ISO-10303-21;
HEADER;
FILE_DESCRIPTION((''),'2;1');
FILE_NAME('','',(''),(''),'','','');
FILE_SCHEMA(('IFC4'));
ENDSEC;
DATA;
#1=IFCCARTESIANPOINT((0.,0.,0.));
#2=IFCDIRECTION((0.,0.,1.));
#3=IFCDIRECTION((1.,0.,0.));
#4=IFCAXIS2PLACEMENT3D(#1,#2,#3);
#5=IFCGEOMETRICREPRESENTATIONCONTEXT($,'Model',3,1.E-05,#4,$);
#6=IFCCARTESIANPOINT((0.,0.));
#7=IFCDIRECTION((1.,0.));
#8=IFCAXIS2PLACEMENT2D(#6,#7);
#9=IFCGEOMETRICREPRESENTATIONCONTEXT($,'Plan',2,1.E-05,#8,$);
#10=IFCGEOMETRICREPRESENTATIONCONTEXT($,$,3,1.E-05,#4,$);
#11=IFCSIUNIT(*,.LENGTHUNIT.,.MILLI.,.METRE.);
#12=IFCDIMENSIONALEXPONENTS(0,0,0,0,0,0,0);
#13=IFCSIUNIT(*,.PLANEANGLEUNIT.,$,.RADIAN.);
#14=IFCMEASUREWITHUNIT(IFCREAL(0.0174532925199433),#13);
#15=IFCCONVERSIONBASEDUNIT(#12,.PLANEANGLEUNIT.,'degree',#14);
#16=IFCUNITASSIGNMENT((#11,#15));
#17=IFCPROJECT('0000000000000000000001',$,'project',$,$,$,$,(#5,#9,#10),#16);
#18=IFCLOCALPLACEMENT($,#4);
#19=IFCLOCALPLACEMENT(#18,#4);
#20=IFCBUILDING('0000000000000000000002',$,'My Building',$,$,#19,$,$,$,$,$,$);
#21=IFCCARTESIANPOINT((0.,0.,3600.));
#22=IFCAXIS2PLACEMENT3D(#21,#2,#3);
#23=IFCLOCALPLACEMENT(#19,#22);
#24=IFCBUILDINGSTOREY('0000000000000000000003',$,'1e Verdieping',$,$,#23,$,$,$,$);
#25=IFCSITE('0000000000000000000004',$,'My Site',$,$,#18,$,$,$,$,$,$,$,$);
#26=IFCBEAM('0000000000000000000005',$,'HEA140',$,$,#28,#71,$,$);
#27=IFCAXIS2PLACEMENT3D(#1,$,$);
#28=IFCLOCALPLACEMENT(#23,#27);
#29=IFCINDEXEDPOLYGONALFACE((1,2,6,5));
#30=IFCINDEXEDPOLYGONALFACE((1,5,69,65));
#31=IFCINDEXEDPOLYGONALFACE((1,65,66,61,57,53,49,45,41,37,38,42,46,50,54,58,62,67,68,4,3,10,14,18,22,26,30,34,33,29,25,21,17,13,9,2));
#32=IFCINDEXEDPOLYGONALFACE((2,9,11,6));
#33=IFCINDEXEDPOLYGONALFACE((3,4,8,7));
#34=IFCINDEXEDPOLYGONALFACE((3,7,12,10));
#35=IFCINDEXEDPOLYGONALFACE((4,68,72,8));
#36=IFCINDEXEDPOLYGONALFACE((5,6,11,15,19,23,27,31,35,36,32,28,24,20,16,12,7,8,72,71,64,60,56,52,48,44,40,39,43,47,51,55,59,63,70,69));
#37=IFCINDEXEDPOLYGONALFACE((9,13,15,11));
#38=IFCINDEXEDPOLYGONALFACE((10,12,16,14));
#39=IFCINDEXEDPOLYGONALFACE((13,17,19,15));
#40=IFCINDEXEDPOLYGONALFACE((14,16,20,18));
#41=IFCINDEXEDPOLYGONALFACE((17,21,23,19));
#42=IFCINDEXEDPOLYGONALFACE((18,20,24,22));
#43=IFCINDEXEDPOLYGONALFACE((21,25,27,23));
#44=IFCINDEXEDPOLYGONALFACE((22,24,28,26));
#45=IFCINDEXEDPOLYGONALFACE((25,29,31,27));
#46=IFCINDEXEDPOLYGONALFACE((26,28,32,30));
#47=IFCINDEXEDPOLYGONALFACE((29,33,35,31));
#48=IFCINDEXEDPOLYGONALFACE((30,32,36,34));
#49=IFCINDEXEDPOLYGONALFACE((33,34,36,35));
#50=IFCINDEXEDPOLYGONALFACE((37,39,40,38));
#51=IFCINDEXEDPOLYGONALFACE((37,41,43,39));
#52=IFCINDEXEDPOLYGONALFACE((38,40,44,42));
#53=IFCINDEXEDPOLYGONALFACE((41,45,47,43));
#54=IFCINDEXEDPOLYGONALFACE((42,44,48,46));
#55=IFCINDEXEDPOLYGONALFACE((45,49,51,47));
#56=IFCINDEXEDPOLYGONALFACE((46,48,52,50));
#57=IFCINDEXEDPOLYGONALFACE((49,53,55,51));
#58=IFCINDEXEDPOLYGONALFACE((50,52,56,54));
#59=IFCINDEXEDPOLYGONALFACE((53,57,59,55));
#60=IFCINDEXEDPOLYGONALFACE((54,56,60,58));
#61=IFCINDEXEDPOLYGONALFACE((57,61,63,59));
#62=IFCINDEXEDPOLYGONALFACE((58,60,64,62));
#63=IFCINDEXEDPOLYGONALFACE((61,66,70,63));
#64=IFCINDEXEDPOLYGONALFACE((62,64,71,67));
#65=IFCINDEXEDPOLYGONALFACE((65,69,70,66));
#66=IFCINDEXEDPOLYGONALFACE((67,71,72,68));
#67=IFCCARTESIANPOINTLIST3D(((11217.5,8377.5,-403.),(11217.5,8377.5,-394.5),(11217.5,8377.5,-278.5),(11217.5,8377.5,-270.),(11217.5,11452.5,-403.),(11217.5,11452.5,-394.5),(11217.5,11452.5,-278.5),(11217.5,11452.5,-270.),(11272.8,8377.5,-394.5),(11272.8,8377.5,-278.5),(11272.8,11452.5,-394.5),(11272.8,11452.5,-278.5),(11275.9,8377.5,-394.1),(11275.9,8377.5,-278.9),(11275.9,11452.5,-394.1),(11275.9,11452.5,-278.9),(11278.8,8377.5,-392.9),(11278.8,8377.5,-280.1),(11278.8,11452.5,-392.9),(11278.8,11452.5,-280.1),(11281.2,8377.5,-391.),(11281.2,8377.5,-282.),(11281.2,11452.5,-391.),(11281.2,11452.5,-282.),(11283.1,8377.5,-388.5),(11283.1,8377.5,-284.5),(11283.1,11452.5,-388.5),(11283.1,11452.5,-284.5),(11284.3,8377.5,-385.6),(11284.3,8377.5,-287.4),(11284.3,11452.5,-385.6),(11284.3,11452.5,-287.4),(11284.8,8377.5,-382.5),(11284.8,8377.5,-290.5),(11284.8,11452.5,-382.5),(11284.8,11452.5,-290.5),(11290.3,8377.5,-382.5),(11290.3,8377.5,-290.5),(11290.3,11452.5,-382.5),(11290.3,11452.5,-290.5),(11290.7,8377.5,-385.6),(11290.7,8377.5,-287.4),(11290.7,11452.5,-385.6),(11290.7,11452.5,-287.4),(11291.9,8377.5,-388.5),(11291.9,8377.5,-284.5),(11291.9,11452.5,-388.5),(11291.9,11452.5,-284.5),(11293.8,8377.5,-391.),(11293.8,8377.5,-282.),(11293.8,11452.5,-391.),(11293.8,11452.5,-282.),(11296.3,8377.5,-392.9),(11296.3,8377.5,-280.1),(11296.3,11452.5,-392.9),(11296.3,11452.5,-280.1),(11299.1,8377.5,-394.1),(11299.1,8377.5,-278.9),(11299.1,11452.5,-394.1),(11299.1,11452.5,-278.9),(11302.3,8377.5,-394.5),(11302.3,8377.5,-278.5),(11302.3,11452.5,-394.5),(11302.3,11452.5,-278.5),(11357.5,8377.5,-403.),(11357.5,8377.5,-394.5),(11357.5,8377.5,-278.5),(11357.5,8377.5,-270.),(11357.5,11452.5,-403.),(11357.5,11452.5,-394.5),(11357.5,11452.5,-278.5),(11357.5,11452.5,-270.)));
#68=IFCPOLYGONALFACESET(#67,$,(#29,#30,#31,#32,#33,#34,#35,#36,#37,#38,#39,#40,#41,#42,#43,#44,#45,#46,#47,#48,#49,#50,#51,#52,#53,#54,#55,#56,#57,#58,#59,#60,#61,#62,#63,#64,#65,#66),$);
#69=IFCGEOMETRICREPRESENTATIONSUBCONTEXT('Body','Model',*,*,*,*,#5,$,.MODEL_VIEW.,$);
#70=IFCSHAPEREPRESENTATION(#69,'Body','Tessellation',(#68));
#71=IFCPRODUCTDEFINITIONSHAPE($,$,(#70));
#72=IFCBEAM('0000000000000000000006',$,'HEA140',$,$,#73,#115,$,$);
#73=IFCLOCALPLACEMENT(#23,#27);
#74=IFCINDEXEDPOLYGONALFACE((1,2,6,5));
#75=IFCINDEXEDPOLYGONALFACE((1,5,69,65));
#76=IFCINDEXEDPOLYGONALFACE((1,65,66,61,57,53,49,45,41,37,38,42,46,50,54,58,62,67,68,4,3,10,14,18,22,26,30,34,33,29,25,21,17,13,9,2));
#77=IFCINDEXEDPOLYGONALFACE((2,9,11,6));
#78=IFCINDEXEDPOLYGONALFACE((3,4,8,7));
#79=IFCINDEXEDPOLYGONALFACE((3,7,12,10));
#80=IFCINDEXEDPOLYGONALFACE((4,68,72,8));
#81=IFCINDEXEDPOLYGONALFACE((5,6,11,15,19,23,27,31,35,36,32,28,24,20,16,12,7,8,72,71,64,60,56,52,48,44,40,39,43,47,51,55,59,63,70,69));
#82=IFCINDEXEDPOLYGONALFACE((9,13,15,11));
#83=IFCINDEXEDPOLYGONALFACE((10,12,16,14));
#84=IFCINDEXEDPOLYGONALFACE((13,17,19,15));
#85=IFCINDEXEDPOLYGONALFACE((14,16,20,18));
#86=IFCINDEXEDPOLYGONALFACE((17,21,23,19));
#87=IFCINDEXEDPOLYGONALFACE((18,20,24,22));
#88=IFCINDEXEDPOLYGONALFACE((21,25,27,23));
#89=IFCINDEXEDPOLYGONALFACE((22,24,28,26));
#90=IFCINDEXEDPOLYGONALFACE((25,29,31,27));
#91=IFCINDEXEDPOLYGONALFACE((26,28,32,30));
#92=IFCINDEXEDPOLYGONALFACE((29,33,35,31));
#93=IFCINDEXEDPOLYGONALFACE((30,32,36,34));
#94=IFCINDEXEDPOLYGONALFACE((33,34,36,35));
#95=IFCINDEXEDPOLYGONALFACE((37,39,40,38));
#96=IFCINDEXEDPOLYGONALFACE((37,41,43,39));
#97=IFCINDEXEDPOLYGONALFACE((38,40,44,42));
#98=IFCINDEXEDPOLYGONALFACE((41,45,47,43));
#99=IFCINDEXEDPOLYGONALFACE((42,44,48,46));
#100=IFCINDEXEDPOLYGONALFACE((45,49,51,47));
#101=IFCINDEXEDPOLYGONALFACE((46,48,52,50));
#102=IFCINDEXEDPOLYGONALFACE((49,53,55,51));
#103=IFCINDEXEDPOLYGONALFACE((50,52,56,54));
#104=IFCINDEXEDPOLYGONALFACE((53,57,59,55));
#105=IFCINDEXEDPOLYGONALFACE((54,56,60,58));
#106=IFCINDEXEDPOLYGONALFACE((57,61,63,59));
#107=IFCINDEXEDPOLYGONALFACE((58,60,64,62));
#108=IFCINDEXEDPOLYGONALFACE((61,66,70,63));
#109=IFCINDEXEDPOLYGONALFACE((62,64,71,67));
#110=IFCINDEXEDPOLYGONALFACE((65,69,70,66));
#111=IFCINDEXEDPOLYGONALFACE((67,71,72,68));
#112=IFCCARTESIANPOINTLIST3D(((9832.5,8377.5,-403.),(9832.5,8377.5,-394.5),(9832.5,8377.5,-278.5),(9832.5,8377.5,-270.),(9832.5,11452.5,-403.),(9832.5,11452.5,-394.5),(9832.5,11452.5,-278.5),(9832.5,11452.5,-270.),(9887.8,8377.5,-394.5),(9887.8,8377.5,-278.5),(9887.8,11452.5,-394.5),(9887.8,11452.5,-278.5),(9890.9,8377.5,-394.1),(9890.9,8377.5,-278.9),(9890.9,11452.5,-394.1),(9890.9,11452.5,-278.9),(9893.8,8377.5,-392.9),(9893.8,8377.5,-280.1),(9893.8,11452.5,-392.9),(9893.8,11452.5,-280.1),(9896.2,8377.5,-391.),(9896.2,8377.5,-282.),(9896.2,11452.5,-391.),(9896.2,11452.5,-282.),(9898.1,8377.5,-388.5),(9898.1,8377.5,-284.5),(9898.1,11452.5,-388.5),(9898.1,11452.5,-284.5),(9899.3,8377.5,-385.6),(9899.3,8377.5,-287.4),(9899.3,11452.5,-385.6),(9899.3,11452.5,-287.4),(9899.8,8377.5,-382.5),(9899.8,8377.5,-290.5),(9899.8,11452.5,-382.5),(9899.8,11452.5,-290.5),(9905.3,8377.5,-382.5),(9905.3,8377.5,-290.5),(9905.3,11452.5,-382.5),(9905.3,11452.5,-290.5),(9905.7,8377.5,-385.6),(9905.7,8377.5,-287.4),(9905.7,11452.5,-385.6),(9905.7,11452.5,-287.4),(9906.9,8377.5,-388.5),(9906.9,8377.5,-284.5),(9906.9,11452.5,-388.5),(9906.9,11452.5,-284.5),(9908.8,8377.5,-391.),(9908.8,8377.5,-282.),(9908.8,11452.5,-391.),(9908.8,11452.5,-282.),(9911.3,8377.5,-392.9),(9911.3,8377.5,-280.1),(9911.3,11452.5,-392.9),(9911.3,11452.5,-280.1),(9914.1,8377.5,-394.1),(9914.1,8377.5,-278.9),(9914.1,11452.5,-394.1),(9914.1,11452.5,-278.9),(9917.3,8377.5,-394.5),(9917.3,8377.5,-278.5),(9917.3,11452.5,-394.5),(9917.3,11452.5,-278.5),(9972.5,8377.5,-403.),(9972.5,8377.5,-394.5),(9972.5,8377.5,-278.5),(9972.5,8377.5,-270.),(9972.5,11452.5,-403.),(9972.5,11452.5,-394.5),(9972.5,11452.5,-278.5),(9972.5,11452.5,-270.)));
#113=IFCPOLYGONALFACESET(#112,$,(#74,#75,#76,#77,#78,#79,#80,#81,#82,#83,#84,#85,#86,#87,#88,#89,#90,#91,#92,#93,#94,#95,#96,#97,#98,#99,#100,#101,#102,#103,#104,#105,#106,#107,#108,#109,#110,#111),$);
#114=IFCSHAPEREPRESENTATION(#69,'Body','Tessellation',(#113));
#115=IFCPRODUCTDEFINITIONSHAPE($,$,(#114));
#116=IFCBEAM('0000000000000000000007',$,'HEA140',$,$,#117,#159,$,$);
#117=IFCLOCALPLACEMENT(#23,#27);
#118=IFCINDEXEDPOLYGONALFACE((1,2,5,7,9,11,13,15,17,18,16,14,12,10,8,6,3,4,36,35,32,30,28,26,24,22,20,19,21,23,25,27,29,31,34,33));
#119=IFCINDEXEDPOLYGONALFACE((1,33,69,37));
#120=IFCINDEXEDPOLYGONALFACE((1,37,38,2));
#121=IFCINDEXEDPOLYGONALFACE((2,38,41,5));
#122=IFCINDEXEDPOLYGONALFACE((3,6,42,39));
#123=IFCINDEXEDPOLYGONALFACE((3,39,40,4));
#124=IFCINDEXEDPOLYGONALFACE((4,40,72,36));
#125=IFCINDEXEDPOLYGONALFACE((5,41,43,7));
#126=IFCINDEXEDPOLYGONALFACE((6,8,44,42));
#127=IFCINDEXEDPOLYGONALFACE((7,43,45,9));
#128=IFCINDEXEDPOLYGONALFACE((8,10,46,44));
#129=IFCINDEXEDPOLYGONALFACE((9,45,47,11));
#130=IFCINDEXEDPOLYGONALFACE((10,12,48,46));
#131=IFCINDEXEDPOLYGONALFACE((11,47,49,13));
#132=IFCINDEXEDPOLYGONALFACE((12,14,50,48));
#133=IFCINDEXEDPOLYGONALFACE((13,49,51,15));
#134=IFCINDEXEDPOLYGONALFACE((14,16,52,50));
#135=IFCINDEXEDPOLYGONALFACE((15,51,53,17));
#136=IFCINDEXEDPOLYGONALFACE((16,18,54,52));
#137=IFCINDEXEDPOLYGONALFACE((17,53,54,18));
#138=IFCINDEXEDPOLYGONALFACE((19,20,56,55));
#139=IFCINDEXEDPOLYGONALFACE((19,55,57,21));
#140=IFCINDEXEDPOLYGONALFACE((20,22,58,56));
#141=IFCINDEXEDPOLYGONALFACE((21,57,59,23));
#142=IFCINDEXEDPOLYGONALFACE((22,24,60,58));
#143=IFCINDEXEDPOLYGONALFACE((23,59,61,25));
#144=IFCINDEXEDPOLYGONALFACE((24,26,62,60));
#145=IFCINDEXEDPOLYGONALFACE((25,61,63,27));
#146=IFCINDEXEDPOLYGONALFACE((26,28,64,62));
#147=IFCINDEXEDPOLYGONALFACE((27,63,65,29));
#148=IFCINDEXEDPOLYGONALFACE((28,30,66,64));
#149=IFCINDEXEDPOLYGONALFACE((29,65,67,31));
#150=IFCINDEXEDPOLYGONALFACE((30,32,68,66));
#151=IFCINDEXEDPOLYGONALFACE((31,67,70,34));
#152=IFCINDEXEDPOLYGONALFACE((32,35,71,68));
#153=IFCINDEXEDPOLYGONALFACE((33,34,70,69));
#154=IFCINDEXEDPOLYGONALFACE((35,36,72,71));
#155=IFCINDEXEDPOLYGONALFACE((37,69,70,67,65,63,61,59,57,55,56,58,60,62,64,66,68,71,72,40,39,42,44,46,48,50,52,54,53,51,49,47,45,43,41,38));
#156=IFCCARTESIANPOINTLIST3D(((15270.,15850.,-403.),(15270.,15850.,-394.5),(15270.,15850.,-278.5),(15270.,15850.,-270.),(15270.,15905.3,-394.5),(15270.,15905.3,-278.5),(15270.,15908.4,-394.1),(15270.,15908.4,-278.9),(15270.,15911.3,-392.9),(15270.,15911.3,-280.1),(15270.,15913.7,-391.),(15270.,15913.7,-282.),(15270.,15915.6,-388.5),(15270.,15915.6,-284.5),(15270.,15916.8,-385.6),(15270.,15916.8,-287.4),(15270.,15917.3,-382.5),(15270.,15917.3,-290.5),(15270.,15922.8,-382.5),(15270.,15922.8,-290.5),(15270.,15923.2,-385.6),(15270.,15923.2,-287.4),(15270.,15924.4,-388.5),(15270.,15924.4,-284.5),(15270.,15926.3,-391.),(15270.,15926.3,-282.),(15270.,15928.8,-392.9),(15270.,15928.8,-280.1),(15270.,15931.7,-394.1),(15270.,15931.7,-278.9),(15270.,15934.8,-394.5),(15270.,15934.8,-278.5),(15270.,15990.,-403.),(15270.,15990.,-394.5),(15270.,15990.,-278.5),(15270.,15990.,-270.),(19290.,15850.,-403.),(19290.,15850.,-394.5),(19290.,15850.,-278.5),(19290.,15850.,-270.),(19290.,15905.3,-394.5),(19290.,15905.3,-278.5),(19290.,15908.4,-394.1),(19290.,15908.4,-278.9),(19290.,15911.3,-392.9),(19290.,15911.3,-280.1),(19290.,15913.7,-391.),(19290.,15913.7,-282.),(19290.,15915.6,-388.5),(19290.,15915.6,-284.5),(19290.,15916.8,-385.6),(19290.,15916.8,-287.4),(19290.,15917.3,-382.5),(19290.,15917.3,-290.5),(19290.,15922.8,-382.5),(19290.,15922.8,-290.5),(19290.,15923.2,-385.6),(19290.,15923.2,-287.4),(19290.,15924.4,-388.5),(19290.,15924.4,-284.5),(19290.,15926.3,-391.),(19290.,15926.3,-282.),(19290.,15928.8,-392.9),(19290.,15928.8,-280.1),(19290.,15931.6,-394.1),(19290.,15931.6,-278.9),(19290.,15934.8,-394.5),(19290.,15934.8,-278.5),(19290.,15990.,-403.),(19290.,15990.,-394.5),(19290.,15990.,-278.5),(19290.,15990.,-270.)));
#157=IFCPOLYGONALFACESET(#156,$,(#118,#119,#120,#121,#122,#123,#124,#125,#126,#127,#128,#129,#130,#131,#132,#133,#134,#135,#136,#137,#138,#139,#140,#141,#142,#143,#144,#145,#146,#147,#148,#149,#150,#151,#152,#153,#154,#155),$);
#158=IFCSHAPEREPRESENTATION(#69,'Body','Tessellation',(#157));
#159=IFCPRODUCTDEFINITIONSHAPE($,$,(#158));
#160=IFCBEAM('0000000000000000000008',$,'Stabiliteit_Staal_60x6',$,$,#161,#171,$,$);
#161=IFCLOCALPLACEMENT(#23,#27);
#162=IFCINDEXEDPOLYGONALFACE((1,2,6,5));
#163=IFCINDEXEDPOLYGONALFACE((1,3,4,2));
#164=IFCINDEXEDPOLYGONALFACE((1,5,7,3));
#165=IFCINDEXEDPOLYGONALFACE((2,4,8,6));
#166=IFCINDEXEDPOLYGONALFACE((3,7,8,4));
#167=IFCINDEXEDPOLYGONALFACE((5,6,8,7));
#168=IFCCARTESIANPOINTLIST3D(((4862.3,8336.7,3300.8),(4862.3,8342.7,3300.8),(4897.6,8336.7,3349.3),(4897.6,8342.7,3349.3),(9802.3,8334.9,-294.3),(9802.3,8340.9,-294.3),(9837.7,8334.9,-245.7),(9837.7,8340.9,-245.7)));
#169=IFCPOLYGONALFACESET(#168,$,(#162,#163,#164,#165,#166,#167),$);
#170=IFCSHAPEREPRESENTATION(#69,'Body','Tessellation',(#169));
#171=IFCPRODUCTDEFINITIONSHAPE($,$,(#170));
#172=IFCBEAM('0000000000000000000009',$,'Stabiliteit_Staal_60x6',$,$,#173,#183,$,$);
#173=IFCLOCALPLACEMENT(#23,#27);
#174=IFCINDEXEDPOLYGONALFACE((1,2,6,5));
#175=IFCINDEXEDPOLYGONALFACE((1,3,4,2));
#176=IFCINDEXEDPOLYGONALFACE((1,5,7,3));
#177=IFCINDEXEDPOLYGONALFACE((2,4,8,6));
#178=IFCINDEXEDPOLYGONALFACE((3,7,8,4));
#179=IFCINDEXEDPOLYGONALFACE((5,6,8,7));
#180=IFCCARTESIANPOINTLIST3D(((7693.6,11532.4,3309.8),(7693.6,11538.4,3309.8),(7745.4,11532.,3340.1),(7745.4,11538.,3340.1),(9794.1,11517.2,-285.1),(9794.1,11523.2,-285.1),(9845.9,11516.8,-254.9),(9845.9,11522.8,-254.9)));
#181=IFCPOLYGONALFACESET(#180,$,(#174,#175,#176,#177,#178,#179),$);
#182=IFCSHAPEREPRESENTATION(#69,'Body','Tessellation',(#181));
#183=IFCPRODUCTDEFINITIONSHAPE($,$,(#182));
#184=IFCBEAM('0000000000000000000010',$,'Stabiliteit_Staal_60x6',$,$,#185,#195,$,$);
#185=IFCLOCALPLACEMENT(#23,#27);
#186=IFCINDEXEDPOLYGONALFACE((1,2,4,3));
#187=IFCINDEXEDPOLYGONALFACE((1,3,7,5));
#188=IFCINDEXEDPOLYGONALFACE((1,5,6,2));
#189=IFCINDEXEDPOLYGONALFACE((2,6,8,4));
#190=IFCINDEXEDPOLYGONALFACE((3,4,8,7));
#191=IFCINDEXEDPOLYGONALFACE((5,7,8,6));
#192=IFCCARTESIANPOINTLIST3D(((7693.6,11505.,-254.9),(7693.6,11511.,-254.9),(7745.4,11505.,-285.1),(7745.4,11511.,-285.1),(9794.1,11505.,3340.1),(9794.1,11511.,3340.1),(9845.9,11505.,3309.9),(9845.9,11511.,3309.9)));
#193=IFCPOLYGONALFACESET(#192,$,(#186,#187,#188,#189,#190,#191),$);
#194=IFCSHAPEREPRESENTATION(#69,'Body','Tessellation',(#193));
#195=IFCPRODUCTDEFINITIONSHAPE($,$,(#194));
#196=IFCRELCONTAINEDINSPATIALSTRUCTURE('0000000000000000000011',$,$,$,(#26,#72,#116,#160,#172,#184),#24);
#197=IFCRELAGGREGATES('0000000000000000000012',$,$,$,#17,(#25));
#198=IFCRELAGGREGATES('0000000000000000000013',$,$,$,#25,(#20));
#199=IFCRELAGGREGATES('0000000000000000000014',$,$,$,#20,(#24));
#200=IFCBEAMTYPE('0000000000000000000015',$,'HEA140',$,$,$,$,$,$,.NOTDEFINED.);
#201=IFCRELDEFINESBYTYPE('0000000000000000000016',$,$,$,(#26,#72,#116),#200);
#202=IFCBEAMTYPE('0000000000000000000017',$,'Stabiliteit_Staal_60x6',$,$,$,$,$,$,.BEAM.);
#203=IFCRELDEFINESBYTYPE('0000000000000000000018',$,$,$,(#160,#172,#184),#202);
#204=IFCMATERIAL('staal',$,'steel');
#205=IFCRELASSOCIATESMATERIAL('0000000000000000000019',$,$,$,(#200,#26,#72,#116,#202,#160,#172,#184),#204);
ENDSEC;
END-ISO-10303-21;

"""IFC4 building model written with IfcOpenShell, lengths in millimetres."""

from ifc_helpers import new_model, entity, si_unit, converted_unit, frame, origin_with_axes, origin_2d_with_axis, place, context, subcontext, project, spatial, rectangle, i_section, extrude, material, material_profile, profile_set, profile_usage, type_object, element, save


model = new_model("IFC4")

# Units and contexts
model_context = context("Model", 3, precision=1e-05, world=origin_with_axes())
plan_context = context("Plan", 2, precision=1e-05, world=origin_2d_with_axis())
context_of_model = context(None, 3, precision=1e-05, world=origin_with_axes())
body_context = subcontext(model_context, "Body", "Model", "MODEL_VIEW")
ifc_project = project(units=[si_unit("LENGTHUNIT", "METRE", prefix="MILLI"), converted_unit("PLANEANGLEUNIT", "degree", entity("IfcReal", 0.0174532925199433), si_unit("PLANEANGLEUNIT", "RADIAN"), dimensions=[0, 0, 0, 0, 0, 0, 0])], contexts=[model_context, plan_context, context_of_model])

# Site, building, storey
site_placement = place(None, origin_with_axes())
site = spatial("IfcSite", under=ifc_project, at=site_placement, Name="My Site")
building_placement = place(site_placement, origin_with_axes())
building = spatial("IfcBuilding", under=site, at=building_placement, Name="My Building")
storey_placement = place(building_placement, frame((0.0, 0.0, 3600.0), z_axis=(0.0, 0.0, 1.0), x_axis=(1.0, 0.0, 0.0)))
storey = spatial("IfcBuildingStorey", under=building, at=storey_placement, Name="1e Verdieping")

# Shared definitions
ifc_material = material(Name="staal", Category="steel")

# Beams
ifc_material_profile_1 = material_profile(ifc_material, i_section(OverallWidth=140.0, OverallDepth=133.0, WebThickness=5.5, FlangeThickness=8.5, FilletRadius=12.0))
ifc_profile_set_1 = profile_set([ifc_material_profile_1], Name="HEA140")
ifc_profile_usage_1 = profile_usage(ifc_profile_set_1)
beam_type_1 = type_object("IfcBeamType", Name="HEA140", PredefinedType="NOTDEFINED", material=ifc_profile_set_1)
beam_1_placement = place(storey_placement, frame((11287.5, 8377.5, -336.5), z_axis=(0.0, 1.0, 0.0), x_axis=(-1.0, 0.0, 0.0)))
element("IfcBeam", 1, at=beam_1_placement, inside=storey, type_object=beam_type_1, material=ifc_profile_usage_1, Name="HEA140", context=body_context, shape_type="SweptSolid", body=[
    extrude(i_section(OverallWidth=140.0, OverallDepth=133.0, WebThickness=5.5, FlangeThickness=8.5, FilletRadius=12.0), origin_with_axes(), (0.0, 0.0, 1.0), 3075.0),
])
ifc_profile_usage_2 = profile_usage(ifc_profile_set_1)
beam_2_placement = place(storey_placement, frame((9902.5, 8377.5, -336.5), z_axis=(0.0, 1.0, 0.0), x_axis=(-1.0, 0.0, 0.0)))
element("IfcBeam", 2, at=beam_2_placement, inside=storey, type_object=beam_type_1, material=ifc_profile_usage_2, Name="HEA140", context=body_context, shape_type="SweptSolid", body=[
    extrude(i_section(OverallWidth=140.0, OverallDepth=133.0, WebThickness=5.5, FlangeThickness=8.5, FilletRadius=12.0), origin_with_axes(), (0.0, 0.0, 1.0), 3075.0),
])
ifc_profile_usage_3 = profile_usage(ifc_profile_set_1)
beam_3_placement = place(storey_placement, frame((19290.0, 15920.0, -336.5), z_axis=(-1.0, 0.0, 0.0), x_axis=(0.0, -1.0, 0.0)))
element("IfcBeam", 3, at=beam_3_placement, inside=storey, type_object=beam_type_1, material=ifc_profile_usage_3, Name="HEA140", context=body_context, shape_type="SweptSolid", body=[
    extrude(i_section(OverallWidth=140.0, OverallDepth=133.0, WebThickness=5.5, FlangeThickness=8.5, FilletRadius=12.0), origin_with_axes(), (0.0, 0.0, 1.0), 4020.0),
])
ifc_material_profile_2 = material_profile(ifc_material, rectangle(XDim=6.0, YDim=60.0, kind="CURVE"))
ifc_profile_set_2 = profile_set([ifc_material_profile_2])
ifc_profile_usage_4 = profile_usage(ifc_profile_set_2)
beam_type_2 = type_object("IfcBeamType", Name="Stabiliteit_Staal_60x6", PredefinedType="BEAM", material=ifc_profile_set_2)
beam_4_placement = place(storey_placement, frame((9820.0, 8337.9, -270.0), z_axis=(-0.808559, 0.000287, 0.588414), x_axis=(-0.000355, -1.0, 0.0)))
element("IfcBeam", 4, at=beam_4_placement, inside=storey, type_object=beam_type_2, material=ifc_profile_usage_4, Name="Stabiliteit_Staal_60x6", context=body_context, shape_type="SweptSolid", body=[
    extrude(rectangle(XDim=6.0, YDim=60.0, kind="CURVE"), origin_with_axes(), (0.0, 0.0, 1.0), 6109.7),
])
ifc_profile_usage_5 = profile_usage(ifc_profile_set_2)
beam_5_placement = place(storey_placement, frame((9820.0, 11520.0, -270.0), z_axis=(-0.50448, 0.003646, 0.863416), x_axis=(-0.007228, -0.999974, 0.0)))
element("IfcBeam", 5, at=beam_5_placement, inside=storey, type_object=beam_type_2, material=ifc_profile_usage_5, Name="Stabiliteit_Staal_60x6", context=body_context, shape_type="SweptSolid", body=[
    extrude(rectangle(XDim=6.0, YDim=60.0, kind="CURVE"), origin_with_axes(), (0.0, 0.0, 1.0), 4163.7),
])
ifc_profile_usage_6 = profile_usage(ifc_profile_set_2)
beam_6_placement = place(storey_placement, frame((7719.5, 11508.0, -270.0), z_axis=(0.504484, 0.0, 0.863421), x_axis=(0.0, 1.0, 0.0)))
element("IfcBeam", 6, at=beam_6_placement, inside=storey, type_object=beam_type_2, material=ifc_profile_usage_6, Name="Stabiliteit_Staal_60x6", context=body_context, shape_type="SweptSolid", body=[
    extrude(rectangle(XDim=6.0, YDim=60.0, kind="CURVE"), origin_with_axes(), (0.0, 0.0, 1.0), 4163.7),
])

save(model, "model.ifc")
